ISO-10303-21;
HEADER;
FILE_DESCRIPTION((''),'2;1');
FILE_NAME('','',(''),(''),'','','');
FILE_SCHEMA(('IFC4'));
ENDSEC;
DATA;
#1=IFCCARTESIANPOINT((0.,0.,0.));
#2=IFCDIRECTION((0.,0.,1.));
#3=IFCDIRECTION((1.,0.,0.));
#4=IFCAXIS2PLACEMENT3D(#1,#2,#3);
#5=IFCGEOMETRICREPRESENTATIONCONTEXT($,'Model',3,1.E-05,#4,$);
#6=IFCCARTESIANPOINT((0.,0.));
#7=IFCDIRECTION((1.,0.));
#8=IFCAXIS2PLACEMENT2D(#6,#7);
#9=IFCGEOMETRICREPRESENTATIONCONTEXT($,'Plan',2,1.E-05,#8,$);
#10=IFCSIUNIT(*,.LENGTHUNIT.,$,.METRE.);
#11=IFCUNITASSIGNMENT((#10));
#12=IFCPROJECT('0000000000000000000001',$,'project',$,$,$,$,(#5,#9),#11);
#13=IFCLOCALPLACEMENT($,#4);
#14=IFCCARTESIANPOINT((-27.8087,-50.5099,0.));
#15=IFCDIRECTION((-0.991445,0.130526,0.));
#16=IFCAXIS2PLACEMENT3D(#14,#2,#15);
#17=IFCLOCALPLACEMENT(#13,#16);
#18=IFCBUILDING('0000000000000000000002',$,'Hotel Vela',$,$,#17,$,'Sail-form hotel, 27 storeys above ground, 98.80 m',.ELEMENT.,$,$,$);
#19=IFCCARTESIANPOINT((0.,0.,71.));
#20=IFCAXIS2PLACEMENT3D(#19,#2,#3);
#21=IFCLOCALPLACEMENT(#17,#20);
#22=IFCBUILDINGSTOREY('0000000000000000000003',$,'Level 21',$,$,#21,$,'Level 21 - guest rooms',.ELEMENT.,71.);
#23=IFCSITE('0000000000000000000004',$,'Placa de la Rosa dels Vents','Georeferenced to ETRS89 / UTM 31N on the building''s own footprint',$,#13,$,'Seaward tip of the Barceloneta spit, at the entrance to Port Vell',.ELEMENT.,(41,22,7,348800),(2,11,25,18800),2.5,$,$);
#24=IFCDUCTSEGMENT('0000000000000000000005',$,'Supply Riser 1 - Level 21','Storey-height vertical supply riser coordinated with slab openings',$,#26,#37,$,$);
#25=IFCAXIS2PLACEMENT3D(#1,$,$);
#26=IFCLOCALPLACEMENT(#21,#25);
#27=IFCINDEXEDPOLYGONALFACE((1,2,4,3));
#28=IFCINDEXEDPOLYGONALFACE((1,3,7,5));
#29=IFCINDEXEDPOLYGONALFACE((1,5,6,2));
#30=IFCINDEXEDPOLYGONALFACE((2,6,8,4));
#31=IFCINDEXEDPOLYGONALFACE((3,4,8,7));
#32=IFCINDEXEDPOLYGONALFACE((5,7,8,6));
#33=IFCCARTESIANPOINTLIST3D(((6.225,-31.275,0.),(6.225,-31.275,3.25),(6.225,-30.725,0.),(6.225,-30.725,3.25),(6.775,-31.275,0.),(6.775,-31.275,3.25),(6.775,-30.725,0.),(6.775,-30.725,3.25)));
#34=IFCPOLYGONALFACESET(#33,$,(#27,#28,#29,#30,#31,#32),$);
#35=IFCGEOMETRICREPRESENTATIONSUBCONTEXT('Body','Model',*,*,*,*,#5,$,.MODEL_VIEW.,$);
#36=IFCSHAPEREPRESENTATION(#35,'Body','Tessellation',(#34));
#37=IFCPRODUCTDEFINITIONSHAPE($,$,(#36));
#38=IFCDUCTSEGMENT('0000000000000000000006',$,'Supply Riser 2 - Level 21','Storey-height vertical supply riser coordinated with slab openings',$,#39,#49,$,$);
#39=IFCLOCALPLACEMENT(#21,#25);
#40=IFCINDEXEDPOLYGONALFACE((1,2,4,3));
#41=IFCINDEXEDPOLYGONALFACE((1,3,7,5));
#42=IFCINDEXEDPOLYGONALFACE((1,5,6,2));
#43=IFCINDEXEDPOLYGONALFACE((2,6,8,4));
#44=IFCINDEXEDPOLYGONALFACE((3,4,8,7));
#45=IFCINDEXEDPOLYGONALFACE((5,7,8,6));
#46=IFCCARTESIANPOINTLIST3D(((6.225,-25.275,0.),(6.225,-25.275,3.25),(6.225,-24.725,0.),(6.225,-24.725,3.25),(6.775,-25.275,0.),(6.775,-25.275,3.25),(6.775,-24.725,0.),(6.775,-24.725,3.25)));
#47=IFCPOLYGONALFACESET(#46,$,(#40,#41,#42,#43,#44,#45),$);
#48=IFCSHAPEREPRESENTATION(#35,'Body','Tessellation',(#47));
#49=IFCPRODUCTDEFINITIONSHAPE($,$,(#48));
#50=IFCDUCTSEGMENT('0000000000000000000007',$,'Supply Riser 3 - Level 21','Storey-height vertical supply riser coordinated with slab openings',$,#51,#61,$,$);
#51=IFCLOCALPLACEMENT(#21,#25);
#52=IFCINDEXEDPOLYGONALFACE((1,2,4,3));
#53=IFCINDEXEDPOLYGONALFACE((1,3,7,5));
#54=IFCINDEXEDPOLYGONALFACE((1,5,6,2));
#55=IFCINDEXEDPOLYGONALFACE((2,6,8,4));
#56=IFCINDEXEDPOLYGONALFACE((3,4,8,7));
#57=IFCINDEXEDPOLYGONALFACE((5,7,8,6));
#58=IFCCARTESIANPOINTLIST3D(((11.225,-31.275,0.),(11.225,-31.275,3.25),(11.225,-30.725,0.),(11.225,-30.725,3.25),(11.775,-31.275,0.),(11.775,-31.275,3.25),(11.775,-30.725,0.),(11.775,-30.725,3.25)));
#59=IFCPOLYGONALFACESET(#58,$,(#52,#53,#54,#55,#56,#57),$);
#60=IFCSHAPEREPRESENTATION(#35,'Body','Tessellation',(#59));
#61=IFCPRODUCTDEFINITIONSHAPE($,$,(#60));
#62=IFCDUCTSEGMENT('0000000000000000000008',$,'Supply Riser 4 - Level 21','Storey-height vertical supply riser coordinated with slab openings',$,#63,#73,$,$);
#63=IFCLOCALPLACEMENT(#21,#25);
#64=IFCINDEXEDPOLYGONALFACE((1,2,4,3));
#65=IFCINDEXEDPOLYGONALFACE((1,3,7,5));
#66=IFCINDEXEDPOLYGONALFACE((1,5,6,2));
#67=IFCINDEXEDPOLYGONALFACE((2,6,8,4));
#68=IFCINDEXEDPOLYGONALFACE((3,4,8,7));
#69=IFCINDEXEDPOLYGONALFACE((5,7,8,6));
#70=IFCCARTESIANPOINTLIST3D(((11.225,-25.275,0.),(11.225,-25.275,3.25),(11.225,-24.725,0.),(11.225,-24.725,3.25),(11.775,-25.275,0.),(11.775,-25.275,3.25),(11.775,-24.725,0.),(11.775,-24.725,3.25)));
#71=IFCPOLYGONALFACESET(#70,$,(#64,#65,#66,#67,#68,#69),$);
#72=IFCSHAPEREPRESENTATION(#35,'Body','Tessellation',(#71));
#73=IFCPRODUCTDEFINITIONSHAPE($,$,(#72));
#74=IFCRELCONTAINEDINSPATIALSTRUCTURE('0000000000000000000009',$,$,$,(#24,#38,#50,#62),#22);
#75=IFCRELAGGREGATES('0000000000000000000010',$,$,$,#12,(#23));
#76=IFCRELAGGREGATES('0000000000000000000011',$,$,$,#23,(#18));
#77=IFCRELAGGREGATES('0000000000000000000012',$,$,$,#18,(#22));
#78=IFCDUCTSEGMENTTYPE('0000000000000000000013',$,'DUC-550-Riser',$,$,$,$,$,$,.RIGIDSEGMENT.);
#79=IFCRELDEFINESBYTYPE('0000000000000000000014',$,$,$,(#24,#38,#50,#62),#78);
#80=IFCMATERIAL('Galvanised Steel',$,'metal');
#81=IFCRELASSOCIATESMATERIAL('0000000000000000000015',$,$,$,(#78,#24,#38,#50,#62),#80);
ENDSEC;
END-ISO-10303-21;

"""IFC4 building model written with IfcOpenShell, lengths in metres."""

from ifc_helpers import new_model, si_unit, frame, origin_with_axes, origin_2d_with_axis, place, context, subcontext, project, spatial, line, indexed_curve, outline, extrude, material, type_object, element, save


model = new_model("IFC4")

# Units and contexts
model_context = context("Model", 3, precision=1e-05, world=origin_with_axes())
plan_context = context("Plan", 2, precision=1e-05, world=origin_2d_with_axis())
body_context = subcontext(model_context, "Body", "Model", "MODEL_VIEW")
ifc_project = project(units=[si_unit("LENGTHUNIT", "METRE")], contexts=[model_context, plan_context])

# Site, building, storey
site_placement = place(None, origin_with_axes())
site = spatial("IfcSite", under=ifc_project, at=site_placement, Name="Placa de la Rosa dels Vents", Description="Georeferenced to ETRS89 / UTM 31N on the building's own footprint", LongName="Seaward tip of the Barceloneta spit, at the entrance to Port Vell", CompositionType="ELEMENT", RefLatitude=(41, 22, 7, 348800), RefLongitude=(2, 11, 25, 18800), RefElevation=2.5)
building_placement = place(site_placement, frame((-27.8087, -50.5099, 0.0), z_axis=(0.0, 0.0, 1.0), x_axis=(-0.991445, 0.130526, 0.0)))
building = spatial("IfcBuilding", under=site, at=building_placement, Name="Hotel Vela", LongName="Sail-form hotel, 27 storeys above ground, 98.80 m", CompositionType="ELEMENT")
storey_placement = place(building_placement, frame((0.0, 0.0, 71.0), z_axis=(0.0, 0.0, 1.0), x_axis=(1.0, 0.0, 0.0)))
storey = spatial("IfcBuildingStorey", under=building, at=storey_placement, Name="Level 21", LongName="Level 21 - guest rooms", CompositionType="ELEMENT", Elevation=71.0)

# Duct segments
ifc_material = material(Name="Galvanised Steel", Category="metal")
duct_segment_type = type_object("IfcDuctSegmentType", Name="DUC-550-Riser", PredefinedType="RIGIDSEGMENT", material=ifc_material)
for number, where, z_axis, x_axis, name in (
    (1, (6.225, -31.275, 0.0), (0.0, 0.0, 1.0), (1.0, 0.0, 0.0), "Supply Riser 1 - Level 21"),
    (2, (6.225, -25.275, 0.0), (0.0, 0.0, 1.0), (1.0, 0.0, 0.0), "Supply Riser 2 - Level 21"),
    (3, (11.225, -31.275, 0.0), (0.0, 0.0, 1.0), (1.0, 0.0, 0.0), "Supply Riser 3 - Level 21"),
    (4, (11.225, -25.275, 0.0), (0.0, 0.0, 1.0), (1.0, 0.0, 0.0), "Supply Riser 4 - Level 21"),
):
    element("IfcDuctSegment", number, at=place(storey_placement, frame(where, z_axis=z_axis, x_axis=x_axis)), inside=storey, type_object=duct_segment_type, material=ifc_material, Name=name, Description="Storey-height vertical supply riser coordinated with slab openings", context=body_context, shape_type="SweptSolid", body=[
        extrude(outline(indexed_curve([(0.0, 0.0), (0.55, 0.0), (0.55, 0.55), (0.0, 0.55)], segments=[line(1, 2, 3, 4, 1)])), origin_with_axes(), (0.0, 0.0, 1.0), 3.25),
    ])

save(model, "model.ifc")
